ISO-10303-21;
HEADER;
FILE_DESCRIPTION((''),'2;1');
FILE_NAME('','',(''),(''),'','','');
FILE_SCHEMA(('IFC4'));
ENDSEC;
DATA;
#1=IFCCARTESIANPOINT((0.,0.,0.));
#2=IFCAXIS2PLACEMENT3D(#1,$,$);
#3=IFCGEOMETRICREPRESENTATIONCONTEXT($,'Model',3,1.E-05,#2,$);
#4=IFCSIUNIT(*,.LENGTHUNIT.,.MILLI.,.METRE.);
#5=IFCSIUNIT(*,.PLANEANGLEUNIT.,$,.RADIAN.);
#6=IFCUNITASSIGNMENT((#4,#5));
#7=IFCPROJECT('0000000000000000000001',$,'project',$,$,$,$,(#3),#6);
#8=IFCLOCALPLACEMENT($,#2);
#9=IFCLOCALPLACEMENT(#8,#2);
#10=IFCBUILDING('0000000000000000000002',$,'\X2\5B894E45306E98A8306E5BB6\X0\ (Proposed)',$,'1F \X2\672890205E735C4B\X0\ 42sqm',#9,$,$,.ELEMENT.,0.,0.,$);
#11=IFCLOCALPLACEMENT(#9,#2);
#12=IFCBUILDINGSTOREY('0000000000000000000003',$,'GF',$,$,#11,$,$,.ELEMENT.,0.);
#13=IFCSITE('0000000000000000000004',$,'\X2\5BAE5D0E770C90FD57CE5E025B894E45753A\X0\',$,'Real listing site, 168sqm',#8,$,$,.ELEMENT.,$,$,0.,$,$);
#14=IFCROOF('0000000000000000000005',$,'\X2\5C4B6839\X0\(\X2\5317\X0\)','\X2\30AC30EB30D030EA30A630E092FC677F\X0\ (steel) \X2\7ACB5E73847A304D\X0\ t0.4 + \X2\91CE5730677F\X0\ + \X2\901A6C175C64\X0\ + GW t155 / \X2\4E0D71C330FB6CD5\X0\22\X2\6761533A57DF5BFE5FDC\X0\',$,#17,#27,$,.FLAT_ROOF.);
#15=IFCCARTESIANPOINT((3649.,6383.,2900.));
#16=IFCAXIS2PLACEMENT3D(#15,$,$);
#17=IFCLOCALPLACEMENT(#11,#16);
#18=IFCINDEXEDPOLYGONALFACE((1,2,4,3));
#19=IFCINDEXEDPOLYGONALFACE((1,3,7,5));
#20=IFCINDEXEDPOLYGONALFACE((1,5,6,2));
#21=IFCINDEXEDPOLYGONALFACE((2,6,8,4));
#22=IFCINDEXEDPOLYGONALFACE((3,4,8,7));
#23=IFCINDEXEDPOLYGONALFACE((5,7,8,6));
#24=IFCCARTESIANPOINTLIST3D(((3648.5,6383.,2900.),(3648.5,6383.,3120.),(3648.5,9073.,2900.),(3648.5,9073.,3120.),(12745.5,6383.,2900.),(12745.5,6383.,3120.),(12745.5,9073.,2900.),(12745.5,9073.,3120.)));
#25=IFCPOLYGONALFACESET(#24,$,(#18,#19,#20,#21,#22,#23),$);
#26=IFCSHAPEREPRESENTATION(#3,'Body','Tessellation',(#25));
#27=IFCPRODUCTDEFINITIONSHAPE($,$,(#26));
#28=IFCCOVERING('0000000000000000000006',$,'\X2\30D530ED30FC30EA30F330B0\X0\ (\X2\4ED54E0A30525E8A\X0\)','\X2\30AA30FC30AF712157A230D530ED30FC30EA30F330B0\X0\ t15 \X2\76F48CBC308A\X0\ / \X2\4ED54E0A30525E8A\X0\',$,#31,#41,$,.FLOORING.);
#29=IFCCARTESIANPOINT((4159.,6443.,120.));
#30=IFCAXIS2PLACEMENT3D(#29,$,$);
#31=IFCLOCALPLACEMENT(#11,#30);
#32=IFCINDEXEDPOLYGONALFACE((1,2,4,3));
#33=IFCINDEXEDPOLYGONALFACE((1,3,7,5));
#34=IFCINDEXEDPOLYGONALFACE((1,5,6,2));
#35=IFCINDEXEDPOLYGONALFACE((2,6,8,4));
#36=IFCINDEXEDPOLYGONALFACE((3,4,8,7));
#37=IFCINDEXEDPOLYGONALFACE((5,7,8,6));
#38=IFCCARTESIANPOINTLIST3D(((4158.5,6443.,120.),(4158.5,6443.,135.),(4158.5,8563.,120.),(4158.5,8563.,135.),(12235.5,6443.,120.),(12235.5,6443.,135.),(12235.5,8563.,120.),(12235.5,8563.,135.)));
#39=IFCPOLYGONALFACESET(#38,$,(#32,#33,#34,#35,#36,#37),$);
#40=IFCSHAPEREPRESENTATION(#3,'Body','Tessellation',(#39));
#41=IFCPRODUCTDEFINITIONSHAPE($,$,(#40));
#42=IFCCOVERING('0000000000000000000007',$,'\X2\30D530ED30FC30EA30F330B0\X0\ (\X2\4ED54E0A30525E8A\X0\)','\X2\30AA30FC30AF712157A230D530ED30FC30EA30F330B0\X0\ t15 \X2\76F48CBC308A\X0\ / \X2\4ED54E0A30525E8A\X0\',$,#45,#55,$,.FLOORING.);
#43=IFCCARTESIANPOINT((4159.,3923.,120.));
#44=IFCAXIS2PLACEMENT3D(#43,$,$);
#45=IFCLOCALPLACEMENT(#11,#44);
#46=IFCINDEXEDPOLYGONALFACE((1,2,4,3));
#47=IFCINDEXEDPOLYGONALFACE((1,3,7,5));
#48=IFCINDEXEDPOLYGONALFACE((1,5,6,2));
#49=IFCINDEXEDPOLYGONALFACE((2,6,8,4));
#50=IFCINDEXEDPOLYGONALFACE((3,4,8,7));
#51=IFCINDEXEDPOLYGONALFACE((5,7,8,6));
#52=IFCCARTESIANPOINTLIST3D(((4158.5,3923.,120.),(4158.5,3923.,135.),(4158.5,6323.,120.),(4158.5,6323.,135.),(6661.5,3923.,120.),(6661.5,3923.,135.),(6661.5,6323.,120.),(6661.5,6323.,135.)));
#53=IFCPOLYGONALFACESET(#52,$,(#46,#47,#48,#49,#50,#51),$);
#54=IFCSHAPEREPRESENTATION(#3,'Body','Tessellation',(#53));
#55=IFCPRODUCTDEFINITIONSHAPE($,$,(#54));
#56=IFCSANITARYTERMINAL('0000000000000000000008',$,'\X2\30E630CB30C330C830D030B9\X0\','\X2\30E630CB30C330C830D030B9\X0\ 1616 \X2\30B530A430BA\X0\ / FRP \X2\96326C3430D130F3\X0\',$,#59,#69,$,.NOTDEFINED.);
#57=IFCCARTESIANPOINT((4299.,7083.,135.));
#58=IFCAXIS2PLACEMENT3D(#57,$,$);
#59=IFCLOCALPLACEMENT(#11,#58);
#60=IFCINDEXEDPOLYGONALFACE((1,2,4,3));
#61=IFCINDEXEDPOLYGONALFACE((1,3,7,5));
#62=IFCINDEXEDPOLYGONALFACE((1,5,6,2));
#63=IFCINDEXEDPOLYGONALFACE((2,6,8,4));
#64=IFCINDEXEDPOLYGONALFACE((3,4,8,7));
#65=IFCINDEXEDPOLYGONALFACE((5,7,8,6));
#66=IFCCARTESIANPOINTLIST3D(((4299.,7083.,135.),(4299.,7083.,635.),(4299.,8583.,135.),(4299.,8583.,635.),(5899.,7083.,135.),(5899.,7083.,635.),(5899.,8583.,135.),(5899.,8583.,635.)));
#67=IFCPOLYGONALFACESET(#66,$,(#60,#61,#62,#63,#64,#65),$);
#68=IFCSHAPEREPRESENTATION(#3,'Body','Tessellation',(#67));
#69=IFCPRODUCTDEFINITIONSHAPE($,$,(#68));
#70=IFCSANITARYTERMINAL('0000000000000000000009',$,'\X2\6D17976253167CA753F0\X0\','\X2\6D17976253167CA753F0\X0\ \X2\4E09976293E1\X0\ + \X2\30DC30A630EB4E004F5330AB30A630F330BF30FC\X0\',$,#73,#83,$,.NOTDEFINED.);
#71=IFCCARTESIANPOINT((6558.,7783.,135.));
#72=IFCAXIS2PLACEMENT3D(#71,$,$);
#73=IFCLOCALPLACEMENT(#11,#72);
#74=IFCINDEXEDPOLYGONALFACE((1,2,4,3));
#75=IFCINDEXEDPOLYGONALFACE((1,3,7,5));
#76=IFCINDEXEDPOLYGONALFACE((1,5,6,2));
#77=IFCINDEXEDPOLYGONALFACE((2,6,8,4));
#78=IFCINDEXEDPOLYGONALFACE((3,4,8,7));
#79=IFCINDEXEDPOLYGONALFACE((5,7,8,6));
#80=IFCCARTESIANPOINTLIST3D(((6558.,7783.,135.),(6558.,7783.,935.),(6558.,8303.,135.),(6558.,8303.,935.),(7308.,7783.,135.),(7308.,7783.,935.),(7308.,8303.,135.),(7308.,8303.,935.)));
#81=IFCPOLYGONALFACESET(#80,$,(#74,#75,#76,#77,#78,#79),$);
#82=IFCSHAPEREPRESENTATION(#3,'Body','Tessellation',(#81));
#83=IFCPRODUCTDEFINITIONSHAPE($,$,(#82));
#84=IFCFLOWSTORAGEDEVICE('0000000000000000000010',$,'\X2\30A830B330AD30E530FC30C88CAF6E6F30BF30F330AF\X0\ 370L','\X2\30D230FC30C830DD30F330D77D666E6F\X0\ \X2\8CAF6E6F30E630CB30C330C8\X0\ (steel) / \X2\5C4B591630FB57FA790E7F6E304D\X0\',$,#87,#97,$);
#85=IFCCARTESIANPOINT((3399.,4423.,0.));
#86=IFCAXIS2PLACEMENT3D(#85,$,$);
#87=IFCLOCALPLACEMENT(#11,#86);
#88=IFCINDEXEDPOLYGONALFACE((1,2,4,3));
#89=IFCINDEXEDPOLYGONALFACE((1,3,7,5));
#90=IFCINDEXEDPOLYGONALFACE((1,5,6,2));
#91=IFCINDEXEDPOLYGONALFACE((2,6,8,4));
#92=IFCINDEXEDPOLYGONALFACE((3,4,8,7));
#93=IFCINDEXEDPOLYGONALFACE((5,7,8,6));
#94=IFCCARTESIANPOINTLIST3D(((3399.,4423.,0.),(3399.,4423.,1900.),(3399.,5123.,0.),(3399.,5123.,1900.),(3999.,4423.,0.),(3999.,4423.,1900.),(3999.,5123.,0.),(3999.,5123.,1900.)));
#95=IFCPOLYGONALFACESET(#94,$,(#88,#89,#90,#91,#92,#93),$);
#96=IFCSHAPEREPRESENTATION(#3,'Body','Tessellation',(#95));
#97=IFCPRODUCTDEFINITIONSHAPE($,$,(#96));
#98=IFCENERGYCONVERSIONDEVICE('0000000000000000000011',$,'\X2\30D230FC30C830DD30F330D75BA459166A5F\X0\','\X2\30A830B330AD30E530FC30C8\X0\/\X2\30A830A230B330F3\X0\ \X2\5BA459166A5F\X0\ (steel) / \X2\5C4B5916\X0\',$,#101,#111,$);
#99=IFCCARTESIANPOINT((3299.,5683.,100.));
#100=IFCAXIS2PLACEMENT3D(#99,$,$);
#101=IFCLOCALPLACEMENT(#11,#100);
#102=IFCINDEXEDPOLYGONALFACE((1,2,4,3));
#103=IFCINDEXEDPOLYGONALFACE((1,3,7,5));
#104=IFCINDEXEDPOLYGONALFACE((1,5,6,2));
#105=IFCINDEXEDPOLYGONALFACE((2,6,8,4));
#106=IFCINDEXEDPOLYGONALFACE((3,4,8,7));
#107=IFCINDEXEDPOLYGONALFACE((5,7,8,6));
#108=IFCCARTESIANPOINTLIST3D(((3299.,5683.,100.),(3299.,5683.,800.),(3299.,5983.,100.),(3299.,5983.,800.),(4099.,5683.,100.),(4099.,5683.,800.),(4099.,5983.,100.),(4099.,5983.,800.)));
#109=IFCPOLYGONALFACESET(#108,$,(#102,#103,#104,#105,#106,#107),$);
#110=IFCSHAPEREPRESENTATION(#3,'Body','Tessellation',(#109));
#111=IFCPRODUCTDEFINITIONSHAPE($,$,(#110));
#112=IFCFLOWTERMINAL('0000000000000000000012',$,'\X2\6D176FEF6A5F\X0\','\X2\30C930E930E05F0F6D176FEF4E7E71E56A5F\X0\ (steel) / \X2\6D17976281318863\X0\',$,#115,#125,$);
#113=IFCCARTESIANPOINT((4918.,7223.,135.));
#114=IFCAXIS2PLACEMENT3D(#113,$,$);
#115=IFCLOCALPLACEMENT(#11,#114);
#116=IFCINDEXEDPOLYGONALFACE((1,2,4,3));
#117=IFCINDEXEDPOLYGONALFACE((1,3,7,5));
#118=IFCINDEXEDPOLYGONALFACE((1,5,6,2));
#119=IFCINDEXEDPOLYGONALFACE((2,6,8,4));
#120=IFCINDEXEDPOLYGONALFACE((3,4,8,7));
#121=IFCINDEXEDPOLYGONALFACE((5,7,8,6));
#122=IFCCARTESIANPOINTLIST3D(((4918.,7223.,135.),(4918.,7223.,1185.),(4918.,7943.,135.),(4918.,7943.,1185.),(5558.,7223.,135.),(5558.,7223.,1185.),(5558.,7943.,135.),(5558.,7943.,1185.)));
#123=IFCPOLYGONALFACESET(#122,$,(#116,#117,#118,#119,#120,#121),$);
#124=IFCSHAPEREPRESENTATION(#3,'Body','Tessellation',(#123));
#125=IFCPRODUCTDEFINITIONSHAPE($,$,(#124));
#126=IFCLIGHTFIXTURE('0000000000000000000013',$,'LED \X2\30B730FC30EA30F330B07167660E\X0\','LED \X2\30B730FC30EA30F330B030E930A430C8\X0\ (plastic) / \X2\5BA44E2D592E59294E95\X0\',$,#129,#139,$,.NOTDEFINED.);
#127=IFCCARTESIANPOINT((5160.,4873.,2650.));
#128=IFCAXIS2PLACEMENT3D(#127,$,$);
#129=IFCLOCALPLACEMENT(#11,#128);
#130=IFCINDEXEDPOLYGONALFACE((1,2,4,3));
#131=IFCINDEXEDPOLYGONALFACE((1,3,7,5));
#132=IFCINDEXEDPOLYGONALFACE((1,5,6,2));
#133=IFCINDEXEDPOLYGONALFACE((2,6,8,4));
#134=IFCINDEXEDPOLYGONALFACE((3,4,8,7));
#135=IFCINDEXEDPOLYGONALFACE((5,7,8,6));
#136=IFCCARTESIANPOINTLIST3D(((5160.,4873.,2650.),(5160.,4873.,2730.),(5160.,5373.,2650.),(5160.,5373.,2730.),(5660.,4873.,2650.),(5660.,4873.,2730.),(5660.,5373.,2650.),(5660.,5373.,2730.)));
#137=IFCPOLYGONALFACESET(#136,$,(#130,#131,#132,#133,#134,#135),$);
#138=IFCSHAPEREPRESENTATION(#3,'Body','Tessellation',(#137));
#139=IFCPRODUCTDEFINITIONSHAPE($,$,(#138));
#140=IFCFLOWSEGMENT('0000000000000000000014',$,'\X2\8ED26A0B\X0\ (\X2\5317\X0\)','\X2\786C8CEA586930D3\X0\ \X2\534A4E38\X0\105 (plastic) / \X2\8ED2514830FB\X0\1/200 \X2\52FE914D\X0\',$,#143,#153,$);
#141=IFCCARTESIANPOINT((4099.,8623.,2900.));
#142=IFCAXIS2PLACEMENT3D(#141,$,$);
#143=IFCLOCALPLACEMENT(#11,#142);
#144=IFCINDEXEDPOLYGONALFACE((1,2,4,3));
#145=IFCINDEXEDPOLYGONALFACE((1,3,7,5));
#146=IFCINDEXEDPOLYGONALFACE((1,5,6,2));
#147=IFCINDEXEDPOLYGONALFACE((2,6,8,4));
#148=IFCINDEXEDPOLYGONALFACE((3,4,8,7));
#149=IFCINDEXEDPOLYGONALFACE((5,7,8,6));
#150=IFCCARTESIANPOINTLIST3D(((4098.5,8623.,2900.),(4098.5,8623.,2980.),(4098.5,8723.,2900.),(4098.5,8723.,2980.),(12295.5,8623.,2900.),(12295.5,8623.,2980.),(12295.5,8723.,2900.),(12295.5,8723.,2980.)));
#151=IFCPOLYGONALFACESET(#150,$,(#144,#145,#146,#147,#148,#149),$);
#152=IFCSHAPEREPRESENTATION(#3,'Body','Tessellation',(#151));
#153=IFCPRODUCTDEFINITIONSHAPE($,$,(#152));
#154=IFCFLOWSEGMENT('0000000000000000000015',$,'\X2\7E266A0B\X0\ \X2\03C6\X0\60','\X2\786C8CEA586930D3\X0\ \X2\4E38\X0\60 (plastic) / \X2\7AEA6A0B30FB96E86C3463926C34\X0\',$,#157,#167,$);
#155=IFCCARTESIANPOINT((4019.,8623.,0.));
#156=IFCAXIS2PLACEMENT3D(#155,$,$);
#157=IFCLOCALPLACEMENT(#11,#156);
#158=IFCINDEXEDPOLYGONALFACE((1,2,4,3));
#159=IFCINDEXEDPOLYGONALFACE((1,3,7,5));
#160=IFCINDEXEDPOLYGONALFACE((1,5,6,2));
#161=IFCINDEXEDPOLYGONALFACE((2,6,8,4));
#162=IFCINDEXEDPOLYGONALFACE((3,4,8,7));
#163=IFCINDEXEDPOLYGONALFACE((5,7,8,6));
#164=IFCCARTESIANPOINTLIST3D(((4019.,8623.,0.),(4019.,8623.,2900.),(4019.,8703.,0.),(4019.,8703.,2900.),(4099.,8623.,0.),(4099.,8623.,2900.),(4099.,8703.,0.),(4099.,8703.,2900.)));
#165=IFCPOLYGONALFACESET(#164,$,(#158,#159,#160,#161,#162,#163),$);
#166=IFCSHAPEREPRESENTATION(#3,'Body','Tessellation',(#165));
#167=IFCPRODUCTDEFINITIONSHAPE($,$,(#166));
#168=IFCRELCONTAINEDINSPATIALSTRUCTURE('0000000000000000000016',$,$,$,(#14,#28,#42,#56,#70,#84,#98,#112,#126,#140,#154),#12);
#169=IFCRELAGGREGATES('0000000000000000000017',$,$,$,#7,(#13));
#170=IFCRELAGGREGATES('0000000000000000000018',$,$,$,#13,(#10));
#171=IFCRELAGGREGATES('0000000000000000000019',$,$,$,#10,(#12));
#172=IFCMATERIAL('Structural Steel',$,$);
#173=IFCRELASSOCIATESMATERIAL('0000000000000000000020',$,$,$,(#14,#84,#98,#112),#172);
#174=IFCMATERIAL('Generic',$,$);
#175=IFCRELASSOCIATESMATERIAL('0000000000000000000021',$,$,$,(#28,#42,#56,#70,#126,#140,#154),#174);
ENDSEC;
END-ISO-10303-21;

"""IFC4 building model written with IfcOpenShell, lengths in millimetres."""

from ifc_helpers import new_model, si_unit, frame, frame_2d, origin, place, context, project, spatial, rectangle, extrude, material, element, save


model = new_model("IFC4")

# Units and contexts
model_context = context("Model", 3, precision=1e-05, world=origin())
ifc_project = project(units=[si_unit("LENGTHUNIT", "METRE", prefix="MILLI"), si_unit("PLANEANGLEUNIT", "RADIAN")], contexts=[model_context])

# Site, building, storey
site_placement = place(None, origin())
site = spatial("IfcSite", under=ifc_project, at=site_placement, Name="宮崎県都城市安久町", ObjectType="Real listing site, 168sqm", CompositionType="ELEMENT", RefElevation=0.0)
building_placement = place(site_placement, origin())
building = spatial("IfcBuilding", under=site, at=building_placement, Name="安久の風の家 (Proposed)", ObjectType="1F 木造平屋 42sqm", CompositionType="ELEMENT", ElevationOfRefHeight=0.0, ElevationOfTerrain=0.0)
storey_placement = place(building_placement, origin())
storey = spatial("IfcBuildingStorey", under=building, at=storey_placement, Name="GF", CompositionType="ELEMENT", Elevation=0.0)

# Roof
ifc_material_1 = material(Name="Structural Steel")
roof_placement = place(storey_placement, frame((3649.0, 6383.0, 2900.0)))
element("IfcRoof", 1, at=roof_placement, inside=storey, material=ifc_material_1, Name="屋根(北)", Description="ガルバリウム鋼板 (steel) 立平葺き t0.4 + 野地板 + 通気層 + GW t155 / 不燃・法22条区域対応", PredefinedType="FLAT_ROOF", context=model_context, shape_type="SweptSolid", body=[
    extrude(rectangle(XDim=9097.0, YDim=2690.0, at=frame_2d((4548.0, 1345.0))), frame((3649.0, 6383.0, 2900.0)), (0.0, 0.0, 1.0), 220.0),
])

# Coverings
ifc_material_2 = material(Name="Generic")
covering_1_placement = place(storey_placement, frame((4159.0, 6443.0, 120.0)))
element("IfcCovering", 2, at=covering_1_placement, inside=storey, material=ifc_material_2, Name="フローリング (仕上げ床)", Description="オーク無垢フローリング t15 直貼り / 仕上げ床", PredefinedType="FLOORING", context=model_context, shape_type="SweptSolid", body=[
    extrude(rectangle(XDim=8077.0, YDim=2120.0, at=frame_2d((4038.0, 1060.0))), frame((4159.0, 6443.0, 120.0)), (0.0, 0.0, 1.0), 15.0),
])
covering_2_placement = place(storey_placement, frame((4159.0, 3923.0, 120.0)))
element("IfcCovering", 3, at=covering_2_placement, inside=storey, material=ifc_material_2, Name="フローリング (仕上げ床)", Description="オーク無垢フローリング t15 直貼り / 仕上げ床", PredefinedType="FLOORING", context=model_context, shape_type="SweptSolid", body=[
    extrude(rectangle(XDim=2503.0, YDim=2400.0, at=frame_2d((1251.0, 1200.0))), frame((4159.0, 3923.0, 120.0)), (0.0, 0.0, 1.0), 15.0),
])

# Sanitary terminals
sanitary_terminal_1_placement = place(storey_placement, frame((4299.0, 7083.0, 135.0)))
element("IfcSanitaryTerminal", 4, at=sanitary_terminal_1_placement, inside=storey, material=ifc_material_2, Name="ユニットバス", Description="ユニットバス 1616 サイズ / FRP 防水パン", PredefinedType="NOTDEFINED", context=model_context, shape_type="SweptSolid", body=[
    extrude(rectangle(XDim=1600.0, YDim=1500.0, at=frame_2d((800.0, 750.0))), frame((4299.0, 7083.0, 135.0)), (0.0, 0.0, 1.0), 500.0),
])
sanitary_terminal_2_placement = place(storey_placement, frame((6558.0, 7783.0, 135.0)))
element("IfcSanitaryTerminal", 5, at=sanitary_terminal_2_placement, inside=storey, material=ifc_material_2, Name="洗面化粧台", Description="洗面化粧台 三面鏡 + ボウル一体カウンター", PredefinedType="NOTDEFINED", context=model_context, shape_type="SweptSolid", body=[
    extrude(rectangle(XDim=750.0, YDim=520.0, at=frame_2d((375.0, 260.0))), frame((6558.0, 7783.0, 135.0)), (0.0, 0.0, 1.0), 800.0),
])

# Flow storage device
flow_storage_device_placement = place(storey_placement, frame((3399.0, 4423.0, 0.0)))
element("IfcFlowStorageDevice", 6, at=flow_storage_device_placement, inside=storey, material=ifc_material_1, Name="エコキュート貯湯タンク 370L", Description="ヒートポンプ給湯 貯湯ユニット (steel) / 屋外・基礎置き", context=model_context, shape_type="SweptSolid", body=[
    extrude(rectangle(XDim=600.0, YDim=700.0, at=frame_2d((300.0, 350.0))), frame((3399.0, 4423.0, 0.0)), (0.0, 0.0, 1.0), 1900.0),
])

# Energy conversion device
energy_conversion_device_placement = place(storey_placement, frame((3299.0, 5683.0, 100.0)))
element("IfcEnergyConversionDevice", 7, at=energy_conversion_device_placement, inside=storey, material=ifc_material_1, Name="ヒートポンプ室外機", Description="エコキュート/エアコン 室外機 (steel) / 屋外", context=model_context, shape_type="SweptSolid", body=[
    extrude(rectangle(XDim=800.0, YDim=300.0, at=frame_2d((400.0, 150.0))), frame((3299.0, 5683.0, 100.0)), (0.0, 0.0, 1.0), 700.0),
])

# Flow terminal
flow_terminal_placement = place(storey_placement, frame((4918.0, 7223.0, 135.0)))
element("IfcFlowTerminal", 8, at=flow_terminal_placement, inside=storey, material=ifc_material_1, Name="洗濯機", Description="ドラム式洗濯乾燥機 (steel) / 洗面脱衣", context=model_context, shape_type="SweptSolid", body=[
    extrude(rectangle(XDim=640.0, YDim=720.0, at=frame_2d((320.0, 360.0))), frame((4918.0, 7223.0, 135.0)), (0.0, 0.0, 1.0), 1050.0),
])

# Light fixture
light_fixture_placement = place(storey_placement, frame((5160.0, 4873.0, 2650.0)))
element("IfcLightFixture", 9, at=light_fixture_placement, inside=storey, material=ifc_material_2, Name="LED シーリング照明", Description="LED シーリングライト (plastic) / 室中央天井", PredefinedType="NOTDEFINED", context=model_context, shape_type="SweptSolid", body=[
    extrude(rectangle(XDim=500.0, YDim=500.0, at=frame_2d((250.0, 250.0))), frame((5160.0, 4873.0, 2650.0)), (0.0, 0.0, 1.0), 80.0),
])

# Flow segments
flow_segment_1_placement = place(storey_placement, frame((4099.0, 8623.0, 2900.0)))
element("IfcFlowSegment", 10, at=flow_segment_1_placement, inside=storey, material=ifc_material_2, Name="軒樋 (北)", Description="硬質塩ビ 半丸105 (plastic) / 軒先・1/200 勾配", context=model_context, shape_type="SweptSolid", body=[
    extrude(rectangle(XDim=8197.0, YDim=100.0, at=frame_2d((4098.0, 50.0))), frame((4099.0, 8623.0, 2900.0)), (0.0, 0.0, 1.0), 80.0),
])
flow_segment_2_placement = place(storey_placement, frame((4019.0, 8623.0, 0.0)))
element("IfcFlowSegment", 11, at=flow_segment_2_placement, inside=storey, material=ifc_material_2, Name="縦樋 φ60", Description="硬質塩ビ 丸60 (plastic) / 竪樋・雨水排水", context=model_context, shape_type="SweptSolid", body=[
    extrude(rectangle(XDim=80.0, YDim=80.0, at=frame_2d((40.0, 40.0))), frame((4019.0, 8623.0, 0.0)), (0.0, 0.0, 1.0), 2900.0),
])

save(model, "model.ifc")
